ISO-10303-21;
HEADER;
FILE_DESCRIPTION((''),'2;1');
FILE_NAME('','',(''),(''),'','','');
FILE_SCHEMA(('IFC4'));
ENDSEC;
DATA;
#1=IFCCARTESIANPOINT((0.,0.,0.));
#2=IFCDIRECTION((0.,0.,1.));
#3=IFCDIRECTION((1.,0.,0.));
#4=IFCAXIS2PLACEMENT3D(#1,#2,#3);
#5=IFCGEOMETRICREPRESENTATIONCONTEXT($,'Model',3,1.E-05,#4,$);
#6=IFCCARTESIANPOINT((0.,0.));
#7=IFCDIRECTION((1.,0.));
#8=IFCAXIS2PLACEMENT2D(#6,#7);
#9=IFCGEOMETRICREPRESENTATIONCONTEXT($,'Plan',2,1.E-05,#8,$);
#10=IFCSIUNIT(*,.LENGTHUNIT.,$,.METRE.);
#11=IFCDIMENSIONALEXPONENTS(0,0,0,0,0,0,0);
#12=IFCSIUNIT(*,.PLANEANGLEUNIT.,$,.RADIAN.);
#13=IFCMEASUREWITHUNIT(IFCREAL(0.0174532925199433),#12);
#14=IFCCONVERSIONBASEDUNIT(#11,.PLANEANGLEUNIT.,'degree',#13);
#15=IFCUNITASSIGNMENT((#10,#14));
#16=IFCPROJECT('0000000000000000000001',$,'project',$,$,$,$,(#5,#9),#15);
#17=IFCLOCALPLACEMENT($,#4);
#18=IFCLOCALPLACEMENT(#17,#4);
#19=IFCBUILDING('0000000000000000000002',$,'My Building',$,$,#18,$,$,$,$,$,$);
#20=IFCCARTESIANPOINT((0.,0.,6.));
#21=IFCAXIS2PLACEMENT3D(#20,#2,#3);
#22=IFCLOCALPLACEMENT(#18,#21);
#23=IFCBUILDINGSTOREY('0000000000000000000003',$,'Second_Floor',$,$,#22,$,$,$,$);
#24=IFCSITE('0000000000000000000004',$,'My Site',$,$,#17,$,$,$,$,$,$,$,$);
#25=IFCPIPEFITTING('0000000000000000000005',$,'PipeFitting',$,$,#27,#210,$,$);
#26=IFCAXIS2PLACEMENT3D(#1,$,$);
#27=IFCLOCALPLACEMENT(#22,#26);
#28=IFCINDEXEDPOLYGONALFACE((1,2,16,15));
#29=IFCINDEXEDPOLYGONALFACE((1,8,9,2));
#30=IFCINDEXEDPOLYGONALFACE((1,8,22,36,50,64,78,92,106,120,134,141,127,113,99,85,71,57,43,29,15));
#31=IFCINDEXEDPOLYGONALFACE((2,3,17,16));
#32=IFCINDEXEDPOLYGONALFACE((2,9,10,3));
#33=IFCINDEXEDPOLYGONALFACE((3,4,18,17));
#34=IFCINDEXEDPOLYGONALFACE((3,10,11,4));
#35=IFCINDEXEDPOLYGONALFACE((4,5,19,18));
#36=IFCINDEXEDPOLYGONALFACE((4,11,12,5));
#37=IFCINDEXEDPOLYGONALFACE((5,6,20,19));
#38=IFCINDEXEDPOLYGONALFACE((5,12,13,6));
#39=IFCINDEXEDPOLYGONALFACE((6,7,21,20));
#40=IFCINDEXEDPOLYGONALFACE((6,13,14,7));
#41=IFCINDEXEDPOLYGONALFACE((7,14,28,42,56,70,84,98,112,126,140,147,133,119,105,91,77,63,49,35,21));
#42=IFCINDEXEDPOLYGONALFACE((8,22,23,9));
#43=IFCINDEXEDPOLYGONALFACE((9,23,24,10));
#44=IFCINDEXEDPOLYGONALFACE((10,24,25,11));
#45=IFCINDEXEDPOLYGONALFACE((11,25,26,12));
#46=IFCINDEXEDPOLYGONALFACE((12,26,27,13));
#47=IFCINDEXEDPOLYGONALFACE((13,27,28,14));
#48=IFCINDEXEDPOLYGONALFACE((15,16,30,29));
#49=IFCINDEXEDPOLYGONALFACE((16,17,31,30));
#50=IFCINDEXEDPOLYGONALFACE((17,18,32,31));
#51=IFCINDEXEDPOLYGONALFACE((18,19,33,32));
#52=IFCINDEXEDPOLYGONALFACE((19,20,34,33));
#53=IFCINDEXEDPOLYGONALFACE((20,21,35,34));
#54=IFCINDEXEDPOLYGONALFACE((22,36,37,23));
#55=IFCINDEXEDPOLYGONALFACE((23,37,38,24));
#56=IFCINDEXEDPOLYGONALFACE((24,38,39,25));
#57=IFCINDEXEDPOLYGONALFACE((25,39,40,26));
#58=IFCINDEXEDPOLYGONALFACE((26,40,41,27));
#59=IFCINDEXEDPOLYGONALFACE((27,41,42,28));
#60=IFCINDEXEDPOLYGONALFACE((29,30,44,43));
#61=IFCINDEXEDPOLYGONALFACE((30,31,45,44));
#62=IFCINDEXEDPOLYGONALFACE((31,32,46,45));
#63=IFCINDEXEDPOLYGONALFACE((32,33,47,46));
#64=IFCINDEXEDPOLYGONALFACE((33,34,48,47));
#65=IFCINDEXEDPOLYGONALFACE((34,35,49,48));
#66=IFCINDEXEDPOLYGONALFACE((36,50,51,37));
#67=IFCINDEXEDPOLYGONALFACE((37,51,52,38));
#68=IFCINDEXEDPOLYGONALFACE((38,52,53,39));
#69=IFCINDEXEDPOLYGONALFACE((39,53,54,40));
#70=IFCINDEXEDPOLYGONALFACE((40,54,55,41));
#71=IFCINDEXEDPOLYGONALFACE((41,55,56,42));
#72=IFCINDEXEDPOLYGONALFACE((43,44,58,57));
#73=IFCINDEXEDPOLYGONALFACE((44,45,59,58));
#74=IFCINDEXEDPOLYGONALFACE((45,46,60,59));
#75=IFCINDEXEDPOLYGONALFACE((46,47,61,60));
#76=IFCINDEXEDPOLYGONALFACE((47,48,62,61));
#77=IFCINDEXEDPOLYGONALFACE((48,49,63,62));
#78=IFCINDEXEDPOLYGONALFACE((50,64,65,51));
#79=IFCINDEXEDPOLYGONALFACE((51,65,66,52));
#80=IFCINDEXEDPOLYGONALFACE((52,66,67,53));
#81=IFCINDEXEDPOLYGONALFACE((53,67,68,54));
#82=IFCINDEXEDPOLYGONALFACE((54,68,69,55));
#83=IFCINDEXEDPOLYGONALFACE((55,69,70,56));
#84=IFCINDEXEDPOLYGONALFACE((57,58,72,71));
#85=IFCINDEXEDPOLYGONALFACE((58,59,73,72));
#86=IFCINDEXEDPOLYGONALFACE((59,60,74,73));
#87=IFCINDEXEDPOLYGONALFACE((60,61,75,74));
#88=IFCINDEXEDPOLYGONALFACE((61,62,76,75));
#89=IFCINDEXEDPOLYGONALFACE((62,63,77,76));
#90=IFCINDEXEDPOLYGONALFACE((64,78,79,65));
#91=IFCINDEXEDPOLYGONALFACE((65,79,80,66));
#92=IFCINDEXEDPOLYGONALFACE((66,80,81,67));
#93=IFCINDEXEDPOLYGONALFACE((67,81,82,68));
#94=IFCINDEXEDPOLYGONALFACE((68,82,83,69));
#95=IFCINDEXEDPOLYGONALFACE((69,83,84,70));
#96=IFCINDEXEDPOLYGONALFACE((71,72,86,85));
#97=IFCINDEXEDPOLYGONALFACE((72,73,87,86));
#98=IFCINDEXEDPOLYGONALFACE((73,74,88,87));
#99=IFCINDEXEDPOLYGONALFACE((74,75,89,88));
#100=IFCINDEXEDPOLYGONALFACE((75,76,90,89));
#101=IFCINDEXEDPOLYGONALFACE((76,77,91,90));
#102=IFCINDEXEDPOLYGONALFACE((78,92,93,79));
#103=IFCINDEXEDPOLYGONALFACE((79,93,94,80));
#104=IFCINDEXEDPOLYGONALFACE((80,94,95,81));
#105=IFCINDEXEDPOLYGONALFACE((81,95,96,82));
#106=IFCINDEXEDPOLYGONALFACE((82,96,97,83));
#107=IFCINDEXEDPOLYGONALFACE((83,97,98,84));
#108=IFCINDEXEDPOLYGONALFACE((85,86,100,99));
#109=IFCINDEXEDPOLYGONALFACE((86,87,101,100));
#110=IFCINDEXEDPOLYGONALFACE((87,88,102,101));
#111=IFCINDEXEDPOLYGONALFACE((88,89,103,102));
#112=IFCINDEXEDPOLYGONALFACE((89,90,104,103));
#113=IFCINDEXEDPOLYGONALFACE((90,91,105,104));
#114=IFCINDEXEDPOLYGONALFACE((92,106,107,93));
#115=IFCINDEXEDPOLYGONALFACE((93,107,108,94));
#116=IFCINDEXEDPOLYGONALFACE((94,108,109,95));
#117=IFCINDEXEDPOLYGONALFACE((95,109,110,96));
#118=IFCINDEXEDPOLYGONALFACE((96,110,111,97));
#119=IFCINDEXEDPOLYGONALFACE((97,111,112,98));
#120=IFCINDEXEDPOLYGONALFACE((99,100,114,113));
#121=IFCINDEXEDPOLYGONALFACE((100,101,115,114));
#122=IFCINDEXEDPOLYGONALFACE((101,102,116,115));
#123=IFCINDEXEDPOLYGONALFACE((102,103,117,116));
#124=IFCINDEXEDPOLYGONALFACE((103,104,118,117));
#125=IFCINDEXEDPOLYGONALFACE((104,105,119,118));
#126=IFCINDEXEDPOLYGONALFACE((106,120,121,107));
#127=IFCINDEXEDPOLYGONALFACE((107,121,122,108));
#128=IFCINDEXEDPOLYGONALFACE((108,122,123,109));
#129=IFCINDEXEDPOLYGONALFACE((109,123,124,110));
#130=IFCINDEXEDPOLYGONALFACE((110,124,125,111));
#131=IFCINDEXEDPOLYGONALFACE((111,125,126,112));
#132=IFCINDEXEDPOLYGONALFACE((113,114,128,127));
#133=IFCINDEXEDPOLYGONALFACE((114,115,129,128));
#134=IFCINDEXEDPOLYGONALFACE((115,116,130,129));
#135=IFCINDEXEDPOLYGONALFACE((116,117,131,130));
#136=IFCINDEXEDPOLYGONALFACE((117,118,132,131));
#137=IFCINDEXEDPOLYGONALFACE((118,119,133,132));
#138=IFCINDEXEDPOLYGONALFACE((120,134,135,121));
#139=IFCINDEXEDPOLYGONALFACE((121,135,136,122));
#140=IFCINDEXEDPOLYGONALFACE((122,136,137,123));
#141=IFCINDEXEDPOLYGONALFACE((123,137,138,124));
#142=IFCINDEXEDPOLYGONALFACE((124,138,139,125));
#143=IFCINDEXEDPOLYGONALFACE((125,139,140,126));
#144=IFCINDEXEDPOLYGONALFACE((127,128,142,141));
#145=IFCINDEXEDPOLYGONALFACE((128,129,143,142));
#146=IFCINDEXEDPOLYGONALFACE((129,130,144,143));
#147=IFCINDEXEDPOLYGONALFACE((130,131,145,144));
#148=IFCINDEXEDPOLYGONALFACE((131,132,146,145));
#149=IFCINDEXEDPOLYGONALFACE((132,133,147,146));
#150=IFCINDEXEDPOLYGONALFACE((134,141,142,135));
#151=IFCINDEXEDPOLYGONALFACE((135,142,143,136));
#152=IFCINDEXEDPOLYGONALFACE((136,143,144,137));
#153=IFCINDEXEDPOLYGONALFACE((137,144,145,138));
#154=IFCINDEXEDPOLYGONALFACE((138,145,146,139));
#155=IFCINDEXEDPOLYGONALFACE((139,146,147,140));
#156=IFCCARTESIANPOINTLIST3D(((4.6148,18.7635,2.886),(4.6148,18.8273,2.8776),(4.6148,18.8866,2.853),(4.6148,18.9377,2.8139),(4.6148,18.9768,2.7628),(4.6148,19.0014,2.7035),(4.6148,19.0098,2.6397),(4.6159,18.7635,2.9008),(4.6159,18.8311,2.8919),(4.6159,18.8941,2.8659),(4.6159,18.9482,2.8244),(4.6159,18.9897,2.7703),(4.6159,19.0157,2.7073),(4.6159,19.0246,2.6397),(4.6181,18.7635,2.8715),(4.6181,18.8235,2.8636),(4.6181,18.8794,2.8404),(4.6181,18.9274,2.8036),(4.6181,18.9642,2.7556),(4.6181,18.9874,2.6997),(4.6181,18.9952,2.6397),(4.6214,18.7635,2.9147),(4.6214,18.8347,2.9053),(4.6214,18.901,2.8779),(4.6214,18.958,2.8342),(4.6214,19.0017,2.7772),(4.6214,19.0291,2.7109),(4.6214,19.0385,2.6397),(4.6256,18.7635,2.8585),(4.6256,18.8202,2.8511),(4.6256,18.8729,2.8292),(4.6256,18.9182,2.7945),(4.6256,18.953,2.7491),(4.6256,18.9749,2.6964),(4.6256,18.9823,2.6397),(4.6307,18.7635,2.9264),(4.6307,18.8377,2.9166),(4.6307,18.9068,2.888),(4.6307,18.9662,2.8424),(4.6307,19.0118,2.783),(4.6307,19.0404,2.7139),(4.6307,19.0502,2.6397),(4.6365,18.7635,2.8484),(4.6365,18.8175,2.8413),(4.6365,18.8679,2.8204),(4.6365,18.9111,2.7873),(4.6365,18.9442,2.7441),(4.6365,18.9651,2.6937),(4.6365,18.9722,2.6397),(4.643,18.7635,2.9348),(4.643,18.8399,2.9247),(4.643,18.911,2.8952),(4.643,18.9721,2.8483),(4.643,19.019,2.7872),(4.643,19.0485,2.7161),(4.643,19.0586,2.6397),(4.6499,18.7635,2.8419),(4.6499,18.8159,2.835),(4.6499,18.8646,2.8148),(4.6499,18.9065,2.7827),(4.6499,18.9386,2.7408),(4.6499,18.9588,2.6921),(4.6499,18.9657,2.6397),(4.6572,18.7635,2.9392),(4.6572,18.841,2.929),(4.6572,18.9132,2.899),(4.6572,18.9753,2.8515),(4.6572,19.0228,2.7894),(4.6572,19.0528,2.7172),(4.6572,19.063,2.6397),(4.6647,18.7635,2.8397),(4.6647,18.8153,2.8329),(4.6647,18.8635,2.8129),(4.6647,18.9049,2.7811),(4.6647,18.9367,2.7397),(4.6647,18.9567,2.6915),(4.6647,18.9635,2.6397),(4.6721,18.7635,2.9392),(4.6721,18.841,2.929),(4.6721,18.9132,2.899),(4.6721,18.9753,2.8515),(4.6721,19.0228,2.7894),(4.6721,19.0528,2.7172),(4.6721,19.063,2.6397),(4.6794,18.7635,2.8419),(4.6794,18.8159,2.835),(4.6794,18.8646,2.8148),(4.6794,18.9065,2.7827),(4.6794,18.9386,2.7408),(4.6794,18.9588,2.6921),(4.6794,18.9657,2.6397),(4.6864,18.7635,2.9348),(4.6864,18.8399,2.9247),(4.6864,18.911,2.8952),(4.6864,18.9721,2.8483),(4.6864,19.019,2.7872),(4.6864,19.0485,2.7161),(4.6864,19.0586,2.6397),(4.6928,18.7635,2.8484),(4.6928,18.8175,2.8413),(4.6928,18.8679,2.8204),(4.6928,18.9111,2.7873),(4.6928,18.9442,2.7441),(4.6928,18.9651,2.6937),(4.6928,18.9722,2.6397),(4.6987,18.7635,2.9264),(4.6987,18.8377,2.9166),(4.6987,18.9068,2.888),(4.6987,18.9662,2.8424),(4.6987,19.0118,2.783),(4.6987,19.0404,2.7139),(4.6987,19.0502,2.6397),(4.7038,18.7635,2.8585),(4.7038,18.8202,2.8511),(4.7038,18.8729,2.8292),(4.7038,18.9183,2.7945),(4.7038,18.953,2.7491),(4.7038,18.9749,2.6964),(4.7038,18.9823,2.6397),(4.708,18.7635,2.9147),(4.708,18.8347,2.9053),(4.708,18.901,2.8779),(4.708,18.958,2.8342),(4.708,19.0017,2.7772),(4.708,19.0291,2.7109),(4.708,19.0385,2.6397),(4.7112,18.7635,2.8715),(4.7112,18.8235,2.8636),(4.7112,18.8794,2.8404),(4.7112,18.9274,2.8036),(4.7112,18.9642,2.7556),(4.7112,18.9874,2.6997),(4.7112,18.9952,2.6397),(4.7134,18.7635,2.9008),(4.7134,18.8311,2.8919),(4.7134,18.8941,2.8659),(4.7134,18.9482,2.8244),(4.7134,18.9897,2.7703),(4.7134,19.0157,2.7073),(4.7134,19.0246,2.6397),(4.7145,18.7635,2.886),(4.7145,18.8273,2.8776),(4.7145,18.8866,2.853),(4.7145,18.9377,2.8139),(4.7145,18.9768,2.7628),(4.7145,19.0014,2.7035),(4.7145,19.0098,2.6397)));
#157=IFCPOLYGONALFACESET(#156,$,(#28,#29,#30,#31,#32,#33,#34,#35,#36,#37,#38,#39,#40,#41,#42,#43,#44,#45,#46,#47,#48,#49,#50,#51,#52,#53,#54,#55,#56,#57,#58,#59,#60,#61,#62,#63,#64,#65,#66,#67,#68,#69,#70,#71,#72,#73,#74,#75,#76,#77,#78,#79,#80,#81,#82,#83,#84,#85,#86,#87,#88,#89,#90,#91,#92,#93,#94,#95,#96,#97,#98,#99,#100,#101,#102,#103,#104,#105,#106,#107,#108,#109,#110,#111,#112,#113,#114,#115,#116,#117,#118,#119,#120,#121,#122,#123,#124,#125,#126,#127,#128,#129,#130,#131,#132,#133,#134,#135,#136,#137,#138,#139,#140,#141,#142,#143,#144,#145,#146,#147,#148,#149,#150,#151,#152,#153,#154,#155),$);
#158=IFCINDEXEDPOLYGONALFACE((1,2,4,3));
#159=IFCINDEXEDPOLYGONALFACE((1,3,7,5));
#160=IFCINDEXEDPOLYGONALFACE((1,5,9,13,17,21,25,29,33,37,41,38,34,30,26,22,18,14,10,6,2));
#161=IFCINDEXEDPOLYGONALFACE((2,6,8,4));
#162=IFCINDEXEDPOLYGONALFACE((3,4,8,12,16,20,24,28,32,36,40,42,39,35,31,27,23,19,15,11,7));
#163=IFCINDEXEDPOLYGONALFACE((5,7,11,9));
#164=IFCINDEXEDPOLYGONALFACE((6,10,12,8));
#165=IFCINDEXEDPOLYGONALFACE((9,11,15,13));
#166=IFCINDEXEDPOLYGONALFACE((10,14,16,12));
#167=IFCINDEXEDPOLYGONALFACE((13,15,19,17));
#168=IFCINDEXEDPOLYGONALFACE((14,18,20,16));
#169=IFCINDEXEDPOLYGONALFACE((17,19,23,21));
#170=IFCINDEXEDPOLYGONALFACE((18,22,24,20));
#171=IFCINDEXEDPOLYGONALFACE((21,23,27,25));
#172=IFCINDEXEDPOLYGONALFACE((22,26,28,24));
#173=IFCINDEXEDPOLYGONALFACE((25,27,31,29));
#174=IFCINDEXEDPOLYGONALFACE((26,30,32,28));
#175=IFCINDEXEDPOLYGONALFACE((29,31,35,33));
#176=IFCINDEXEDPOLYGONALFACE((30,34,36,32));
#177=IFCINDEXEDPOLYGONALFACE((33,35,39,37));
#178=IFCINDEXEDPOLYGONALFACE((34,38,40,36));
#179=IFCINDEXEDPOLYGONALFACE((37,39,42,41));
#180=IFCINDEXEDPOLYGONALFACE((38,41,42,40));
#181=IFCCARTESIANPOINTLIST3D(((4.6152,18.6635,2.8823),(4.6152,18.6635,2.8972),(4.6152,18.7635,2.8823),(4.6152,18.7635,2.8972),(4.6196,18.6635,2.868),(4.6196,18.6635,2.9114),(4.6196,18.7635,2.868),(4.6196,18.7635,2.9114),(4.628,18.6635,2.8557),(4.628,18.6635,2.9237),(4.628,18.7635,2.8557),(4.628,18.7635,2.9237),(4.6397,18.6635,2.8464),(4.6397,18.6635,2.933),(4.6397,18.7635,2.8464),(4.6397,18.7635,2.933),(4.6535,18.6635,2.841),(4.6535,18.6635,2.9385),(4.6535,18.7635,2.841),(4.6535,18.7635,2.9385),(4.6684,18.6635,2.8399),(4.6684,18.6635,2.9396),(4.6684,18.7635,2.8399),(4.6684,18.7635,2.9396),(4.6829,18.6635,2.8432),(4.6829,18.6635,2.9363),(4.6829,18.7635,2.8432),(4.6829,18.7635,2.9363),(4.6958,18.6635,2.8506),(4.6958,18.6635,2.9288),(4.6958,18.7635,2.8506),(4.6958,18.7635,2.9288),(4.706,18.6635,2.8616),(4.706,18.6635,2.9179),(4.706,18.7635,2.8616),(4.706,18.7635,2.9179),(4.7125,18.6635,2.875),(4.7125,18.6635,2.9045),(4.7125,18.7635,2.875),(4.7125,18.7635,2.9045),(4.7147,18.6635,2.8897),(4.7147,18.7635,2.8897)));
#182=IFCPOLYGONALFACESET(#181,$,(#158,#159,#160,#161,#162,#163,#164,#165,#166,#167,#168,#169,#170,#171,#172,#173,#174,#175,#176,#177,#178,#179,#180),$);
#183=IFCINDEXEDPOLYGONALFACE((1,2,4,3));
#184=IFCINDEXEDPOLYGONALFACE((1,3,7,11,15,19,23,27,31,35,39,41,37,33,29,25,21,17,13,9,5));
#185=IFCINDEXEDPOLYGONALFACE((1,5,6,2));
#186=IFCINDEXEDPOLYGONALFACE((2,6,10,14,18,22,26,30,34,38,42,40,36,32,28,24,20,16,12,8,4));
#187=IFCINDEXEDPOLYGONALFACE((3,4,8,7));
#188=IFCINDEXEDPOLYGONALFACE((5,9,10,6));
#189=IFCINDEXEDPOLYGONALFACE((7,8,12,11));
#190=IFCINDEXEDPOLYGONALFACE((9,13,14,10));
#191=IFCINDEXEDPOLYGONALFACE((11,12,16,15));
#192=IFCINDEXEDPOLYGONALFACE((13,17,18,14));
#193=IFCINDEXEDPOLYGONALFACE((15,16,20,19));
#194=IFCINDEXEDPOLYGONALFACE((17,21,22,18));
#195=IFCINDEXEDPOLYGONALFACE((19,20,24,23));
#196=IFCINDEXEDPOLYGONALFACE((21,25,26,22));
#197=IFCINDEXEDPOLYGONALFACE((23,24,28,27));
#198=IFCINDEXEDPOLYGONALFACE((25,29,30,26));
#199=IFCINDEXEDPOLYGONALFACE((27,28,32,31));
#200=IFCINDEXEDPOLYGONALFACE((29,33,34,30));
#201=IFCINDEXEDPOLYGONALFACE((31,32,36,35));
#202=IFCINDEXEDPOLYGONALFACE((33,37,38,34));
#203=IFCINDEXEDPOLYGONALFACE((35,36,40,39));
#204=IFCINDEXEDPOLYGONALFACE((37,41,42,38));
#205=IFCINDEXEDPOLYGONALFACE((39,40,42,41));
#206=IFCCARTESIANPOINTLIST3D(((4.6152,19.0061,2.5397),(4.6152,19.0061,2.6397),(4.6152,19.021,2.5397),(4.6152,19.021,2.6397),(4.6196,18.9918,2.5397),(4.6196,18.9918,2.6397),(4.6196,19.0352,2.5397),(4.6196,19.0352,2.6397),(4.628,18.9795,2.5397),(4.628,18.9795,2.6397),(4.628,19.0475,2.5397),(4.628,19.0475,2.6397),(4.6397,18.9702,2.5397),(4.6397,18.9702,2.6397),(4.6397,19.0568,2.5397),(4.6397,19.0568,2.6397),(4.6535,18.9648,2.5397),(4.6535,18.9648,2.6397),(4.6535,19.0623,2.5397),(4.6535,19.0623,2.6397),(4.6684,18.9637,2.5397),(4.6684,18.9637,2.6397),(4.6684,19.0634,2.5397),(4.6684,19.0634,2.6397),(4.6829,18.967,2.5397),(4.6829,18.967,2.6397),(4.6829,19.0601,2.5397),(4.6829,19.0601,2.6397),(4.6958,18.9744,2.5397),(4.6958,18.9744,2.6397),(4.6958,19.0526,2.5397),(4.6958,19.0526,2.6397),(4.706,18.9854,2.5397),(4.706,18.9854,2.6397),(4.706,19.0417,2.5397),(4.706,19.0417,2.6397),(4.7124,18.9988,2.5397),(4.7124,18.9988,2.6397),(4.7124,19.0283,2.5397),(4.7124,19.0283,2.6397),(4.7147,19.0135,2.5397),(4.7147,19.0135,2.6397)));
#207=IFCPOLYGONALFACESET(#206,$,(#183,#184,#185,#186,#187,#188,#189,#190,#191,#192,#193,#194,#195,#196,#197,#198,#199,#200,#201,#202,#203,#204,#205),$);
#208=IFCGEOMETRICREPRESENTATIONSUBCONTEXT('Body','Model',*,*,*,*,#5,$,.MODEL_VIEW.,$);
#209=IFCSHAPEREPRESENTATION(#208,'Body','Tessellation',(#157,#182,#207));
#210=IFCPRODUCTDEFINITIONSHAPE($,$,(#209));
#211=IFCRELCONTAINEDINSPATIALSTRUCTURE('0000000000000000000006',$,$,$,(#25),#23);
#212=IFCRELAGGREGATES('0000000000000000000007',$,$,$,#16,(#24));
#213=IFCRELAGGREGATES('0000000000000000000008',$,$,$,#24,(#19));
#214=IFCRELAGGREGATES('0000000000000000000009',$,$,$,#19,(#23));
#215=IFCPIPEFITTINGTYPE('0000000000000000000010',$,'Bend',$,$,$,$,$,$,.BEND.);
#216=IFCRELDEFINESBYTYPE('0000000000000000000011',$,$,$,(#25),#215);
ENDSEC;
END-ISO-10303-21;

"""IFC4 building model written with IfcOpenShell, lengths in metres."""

from ifc_helpers import new_model, entity, si_unit, converted_unit, frame, origin_with_axes, origin_2d_with_axis, place, context, subcontext, project, spatial, circle, extrude, source, transform, mapped, type_object, type_shapes, element, save


model = new_model("IFC4")

# Units and contexts
model_context = context("Model", 3, precision=1e-05, world=origin_with_axes())
plan_context = context("Plan", 2, precision=1e-05, world=origin_2d_with_axis())
body_context_1 = subcontext(model_context, "Body", "Model", "MODEL_VIEW")
ifc_project = project(units=[si_unit("LENGTHUNIT", "METRE"), converted_unit("PLANEANGLEUNIT", "degree", entity("IfcReal", 0.0174532925199433), si_unit("PLANEANGLEUNIT", "RADIAN"), dimensions=[0, 0, 0, 0, 0, 0, 0])], contexts=[model_context, plan_context])

# Site, building, storey
site_placement = place(None, origin_with_axes())
site = spatial("IfcSite", under=ifc_project, at=site_placement, Name="My Site")
building_placement = place(site_placement, origin_with_axes())
building = spatial("IfcBuilding", under=site, at=building_placement, Name="My Building")
storey_placement = place(building_placement, frame((0.0, 0.0, 6.0), z_axis=(0.0, 0.0, 1.0), x_axis=(1.0, 0.0, 0.0)))
storey = spatial("IfcBuildingStorey", under=building, at=storey_placement, Name="Second_Floor")

# Pipe fitting
pipe_fitting_type = type_object("IfcPipeFittingType", Name="Bend", PredefinedType="BEND")
shared_shape_1 = source(origin_with_axes(), body_context_1, "Body", "SolidModel", [
    entity("IfcSweptDiskSolid", entity("IfcIndexedPolyCurve", entity("IfcCartesianPointList3D", [[0.0, 0.0, -0.1], [0.0, -0.0732, -0.2768], [0.0, -0.25, -0.35]]), [entity("IfcArcIndex", [1, 2, 3])]), 0.05),
    extrude(circle(Radius=0.05), origin_with_axes(), (0.0, 0.0, -1.0), 0.1),
    extrude(circle(Radius=0.05), frame((0.0, -0.25, -0.35), z_axis=(0.0, -1.0, 0.0), x_axis=(1.0, 0.0, 0.0)), (0.0, 0.0, 1.0), 0.1),
])
type_shapes(pipe_fitting_type, [shared_shape_1])
for number, where, z_axis, x_axis, name in (
    (1, (4.6647, 18.6635, 2.8897), (0.0, -1.0, 0.0), (1.0, 0.0, 0.0), "PipeFitting"),
):
    element("IfcPipeFitting", number, at=place(storey_placement, frame(where, z_axis=z_axis, x_axis=x_axis)), inside=storey, type_object=pipe_fitting_type, Name=name, context=body_context_1, shape_type="MappedRepresentation", body=[
        mapped(shared_shape_1, transform((0.0, 0.0, 0.0), x_axis=(1.0, 0.0, 0.0), y_axis=(0.0, 1.0, 0.0), z_axis=(0.0, 0.0, 1.0), scale=1.0)),
    ])

save(model, "model.ifc")
